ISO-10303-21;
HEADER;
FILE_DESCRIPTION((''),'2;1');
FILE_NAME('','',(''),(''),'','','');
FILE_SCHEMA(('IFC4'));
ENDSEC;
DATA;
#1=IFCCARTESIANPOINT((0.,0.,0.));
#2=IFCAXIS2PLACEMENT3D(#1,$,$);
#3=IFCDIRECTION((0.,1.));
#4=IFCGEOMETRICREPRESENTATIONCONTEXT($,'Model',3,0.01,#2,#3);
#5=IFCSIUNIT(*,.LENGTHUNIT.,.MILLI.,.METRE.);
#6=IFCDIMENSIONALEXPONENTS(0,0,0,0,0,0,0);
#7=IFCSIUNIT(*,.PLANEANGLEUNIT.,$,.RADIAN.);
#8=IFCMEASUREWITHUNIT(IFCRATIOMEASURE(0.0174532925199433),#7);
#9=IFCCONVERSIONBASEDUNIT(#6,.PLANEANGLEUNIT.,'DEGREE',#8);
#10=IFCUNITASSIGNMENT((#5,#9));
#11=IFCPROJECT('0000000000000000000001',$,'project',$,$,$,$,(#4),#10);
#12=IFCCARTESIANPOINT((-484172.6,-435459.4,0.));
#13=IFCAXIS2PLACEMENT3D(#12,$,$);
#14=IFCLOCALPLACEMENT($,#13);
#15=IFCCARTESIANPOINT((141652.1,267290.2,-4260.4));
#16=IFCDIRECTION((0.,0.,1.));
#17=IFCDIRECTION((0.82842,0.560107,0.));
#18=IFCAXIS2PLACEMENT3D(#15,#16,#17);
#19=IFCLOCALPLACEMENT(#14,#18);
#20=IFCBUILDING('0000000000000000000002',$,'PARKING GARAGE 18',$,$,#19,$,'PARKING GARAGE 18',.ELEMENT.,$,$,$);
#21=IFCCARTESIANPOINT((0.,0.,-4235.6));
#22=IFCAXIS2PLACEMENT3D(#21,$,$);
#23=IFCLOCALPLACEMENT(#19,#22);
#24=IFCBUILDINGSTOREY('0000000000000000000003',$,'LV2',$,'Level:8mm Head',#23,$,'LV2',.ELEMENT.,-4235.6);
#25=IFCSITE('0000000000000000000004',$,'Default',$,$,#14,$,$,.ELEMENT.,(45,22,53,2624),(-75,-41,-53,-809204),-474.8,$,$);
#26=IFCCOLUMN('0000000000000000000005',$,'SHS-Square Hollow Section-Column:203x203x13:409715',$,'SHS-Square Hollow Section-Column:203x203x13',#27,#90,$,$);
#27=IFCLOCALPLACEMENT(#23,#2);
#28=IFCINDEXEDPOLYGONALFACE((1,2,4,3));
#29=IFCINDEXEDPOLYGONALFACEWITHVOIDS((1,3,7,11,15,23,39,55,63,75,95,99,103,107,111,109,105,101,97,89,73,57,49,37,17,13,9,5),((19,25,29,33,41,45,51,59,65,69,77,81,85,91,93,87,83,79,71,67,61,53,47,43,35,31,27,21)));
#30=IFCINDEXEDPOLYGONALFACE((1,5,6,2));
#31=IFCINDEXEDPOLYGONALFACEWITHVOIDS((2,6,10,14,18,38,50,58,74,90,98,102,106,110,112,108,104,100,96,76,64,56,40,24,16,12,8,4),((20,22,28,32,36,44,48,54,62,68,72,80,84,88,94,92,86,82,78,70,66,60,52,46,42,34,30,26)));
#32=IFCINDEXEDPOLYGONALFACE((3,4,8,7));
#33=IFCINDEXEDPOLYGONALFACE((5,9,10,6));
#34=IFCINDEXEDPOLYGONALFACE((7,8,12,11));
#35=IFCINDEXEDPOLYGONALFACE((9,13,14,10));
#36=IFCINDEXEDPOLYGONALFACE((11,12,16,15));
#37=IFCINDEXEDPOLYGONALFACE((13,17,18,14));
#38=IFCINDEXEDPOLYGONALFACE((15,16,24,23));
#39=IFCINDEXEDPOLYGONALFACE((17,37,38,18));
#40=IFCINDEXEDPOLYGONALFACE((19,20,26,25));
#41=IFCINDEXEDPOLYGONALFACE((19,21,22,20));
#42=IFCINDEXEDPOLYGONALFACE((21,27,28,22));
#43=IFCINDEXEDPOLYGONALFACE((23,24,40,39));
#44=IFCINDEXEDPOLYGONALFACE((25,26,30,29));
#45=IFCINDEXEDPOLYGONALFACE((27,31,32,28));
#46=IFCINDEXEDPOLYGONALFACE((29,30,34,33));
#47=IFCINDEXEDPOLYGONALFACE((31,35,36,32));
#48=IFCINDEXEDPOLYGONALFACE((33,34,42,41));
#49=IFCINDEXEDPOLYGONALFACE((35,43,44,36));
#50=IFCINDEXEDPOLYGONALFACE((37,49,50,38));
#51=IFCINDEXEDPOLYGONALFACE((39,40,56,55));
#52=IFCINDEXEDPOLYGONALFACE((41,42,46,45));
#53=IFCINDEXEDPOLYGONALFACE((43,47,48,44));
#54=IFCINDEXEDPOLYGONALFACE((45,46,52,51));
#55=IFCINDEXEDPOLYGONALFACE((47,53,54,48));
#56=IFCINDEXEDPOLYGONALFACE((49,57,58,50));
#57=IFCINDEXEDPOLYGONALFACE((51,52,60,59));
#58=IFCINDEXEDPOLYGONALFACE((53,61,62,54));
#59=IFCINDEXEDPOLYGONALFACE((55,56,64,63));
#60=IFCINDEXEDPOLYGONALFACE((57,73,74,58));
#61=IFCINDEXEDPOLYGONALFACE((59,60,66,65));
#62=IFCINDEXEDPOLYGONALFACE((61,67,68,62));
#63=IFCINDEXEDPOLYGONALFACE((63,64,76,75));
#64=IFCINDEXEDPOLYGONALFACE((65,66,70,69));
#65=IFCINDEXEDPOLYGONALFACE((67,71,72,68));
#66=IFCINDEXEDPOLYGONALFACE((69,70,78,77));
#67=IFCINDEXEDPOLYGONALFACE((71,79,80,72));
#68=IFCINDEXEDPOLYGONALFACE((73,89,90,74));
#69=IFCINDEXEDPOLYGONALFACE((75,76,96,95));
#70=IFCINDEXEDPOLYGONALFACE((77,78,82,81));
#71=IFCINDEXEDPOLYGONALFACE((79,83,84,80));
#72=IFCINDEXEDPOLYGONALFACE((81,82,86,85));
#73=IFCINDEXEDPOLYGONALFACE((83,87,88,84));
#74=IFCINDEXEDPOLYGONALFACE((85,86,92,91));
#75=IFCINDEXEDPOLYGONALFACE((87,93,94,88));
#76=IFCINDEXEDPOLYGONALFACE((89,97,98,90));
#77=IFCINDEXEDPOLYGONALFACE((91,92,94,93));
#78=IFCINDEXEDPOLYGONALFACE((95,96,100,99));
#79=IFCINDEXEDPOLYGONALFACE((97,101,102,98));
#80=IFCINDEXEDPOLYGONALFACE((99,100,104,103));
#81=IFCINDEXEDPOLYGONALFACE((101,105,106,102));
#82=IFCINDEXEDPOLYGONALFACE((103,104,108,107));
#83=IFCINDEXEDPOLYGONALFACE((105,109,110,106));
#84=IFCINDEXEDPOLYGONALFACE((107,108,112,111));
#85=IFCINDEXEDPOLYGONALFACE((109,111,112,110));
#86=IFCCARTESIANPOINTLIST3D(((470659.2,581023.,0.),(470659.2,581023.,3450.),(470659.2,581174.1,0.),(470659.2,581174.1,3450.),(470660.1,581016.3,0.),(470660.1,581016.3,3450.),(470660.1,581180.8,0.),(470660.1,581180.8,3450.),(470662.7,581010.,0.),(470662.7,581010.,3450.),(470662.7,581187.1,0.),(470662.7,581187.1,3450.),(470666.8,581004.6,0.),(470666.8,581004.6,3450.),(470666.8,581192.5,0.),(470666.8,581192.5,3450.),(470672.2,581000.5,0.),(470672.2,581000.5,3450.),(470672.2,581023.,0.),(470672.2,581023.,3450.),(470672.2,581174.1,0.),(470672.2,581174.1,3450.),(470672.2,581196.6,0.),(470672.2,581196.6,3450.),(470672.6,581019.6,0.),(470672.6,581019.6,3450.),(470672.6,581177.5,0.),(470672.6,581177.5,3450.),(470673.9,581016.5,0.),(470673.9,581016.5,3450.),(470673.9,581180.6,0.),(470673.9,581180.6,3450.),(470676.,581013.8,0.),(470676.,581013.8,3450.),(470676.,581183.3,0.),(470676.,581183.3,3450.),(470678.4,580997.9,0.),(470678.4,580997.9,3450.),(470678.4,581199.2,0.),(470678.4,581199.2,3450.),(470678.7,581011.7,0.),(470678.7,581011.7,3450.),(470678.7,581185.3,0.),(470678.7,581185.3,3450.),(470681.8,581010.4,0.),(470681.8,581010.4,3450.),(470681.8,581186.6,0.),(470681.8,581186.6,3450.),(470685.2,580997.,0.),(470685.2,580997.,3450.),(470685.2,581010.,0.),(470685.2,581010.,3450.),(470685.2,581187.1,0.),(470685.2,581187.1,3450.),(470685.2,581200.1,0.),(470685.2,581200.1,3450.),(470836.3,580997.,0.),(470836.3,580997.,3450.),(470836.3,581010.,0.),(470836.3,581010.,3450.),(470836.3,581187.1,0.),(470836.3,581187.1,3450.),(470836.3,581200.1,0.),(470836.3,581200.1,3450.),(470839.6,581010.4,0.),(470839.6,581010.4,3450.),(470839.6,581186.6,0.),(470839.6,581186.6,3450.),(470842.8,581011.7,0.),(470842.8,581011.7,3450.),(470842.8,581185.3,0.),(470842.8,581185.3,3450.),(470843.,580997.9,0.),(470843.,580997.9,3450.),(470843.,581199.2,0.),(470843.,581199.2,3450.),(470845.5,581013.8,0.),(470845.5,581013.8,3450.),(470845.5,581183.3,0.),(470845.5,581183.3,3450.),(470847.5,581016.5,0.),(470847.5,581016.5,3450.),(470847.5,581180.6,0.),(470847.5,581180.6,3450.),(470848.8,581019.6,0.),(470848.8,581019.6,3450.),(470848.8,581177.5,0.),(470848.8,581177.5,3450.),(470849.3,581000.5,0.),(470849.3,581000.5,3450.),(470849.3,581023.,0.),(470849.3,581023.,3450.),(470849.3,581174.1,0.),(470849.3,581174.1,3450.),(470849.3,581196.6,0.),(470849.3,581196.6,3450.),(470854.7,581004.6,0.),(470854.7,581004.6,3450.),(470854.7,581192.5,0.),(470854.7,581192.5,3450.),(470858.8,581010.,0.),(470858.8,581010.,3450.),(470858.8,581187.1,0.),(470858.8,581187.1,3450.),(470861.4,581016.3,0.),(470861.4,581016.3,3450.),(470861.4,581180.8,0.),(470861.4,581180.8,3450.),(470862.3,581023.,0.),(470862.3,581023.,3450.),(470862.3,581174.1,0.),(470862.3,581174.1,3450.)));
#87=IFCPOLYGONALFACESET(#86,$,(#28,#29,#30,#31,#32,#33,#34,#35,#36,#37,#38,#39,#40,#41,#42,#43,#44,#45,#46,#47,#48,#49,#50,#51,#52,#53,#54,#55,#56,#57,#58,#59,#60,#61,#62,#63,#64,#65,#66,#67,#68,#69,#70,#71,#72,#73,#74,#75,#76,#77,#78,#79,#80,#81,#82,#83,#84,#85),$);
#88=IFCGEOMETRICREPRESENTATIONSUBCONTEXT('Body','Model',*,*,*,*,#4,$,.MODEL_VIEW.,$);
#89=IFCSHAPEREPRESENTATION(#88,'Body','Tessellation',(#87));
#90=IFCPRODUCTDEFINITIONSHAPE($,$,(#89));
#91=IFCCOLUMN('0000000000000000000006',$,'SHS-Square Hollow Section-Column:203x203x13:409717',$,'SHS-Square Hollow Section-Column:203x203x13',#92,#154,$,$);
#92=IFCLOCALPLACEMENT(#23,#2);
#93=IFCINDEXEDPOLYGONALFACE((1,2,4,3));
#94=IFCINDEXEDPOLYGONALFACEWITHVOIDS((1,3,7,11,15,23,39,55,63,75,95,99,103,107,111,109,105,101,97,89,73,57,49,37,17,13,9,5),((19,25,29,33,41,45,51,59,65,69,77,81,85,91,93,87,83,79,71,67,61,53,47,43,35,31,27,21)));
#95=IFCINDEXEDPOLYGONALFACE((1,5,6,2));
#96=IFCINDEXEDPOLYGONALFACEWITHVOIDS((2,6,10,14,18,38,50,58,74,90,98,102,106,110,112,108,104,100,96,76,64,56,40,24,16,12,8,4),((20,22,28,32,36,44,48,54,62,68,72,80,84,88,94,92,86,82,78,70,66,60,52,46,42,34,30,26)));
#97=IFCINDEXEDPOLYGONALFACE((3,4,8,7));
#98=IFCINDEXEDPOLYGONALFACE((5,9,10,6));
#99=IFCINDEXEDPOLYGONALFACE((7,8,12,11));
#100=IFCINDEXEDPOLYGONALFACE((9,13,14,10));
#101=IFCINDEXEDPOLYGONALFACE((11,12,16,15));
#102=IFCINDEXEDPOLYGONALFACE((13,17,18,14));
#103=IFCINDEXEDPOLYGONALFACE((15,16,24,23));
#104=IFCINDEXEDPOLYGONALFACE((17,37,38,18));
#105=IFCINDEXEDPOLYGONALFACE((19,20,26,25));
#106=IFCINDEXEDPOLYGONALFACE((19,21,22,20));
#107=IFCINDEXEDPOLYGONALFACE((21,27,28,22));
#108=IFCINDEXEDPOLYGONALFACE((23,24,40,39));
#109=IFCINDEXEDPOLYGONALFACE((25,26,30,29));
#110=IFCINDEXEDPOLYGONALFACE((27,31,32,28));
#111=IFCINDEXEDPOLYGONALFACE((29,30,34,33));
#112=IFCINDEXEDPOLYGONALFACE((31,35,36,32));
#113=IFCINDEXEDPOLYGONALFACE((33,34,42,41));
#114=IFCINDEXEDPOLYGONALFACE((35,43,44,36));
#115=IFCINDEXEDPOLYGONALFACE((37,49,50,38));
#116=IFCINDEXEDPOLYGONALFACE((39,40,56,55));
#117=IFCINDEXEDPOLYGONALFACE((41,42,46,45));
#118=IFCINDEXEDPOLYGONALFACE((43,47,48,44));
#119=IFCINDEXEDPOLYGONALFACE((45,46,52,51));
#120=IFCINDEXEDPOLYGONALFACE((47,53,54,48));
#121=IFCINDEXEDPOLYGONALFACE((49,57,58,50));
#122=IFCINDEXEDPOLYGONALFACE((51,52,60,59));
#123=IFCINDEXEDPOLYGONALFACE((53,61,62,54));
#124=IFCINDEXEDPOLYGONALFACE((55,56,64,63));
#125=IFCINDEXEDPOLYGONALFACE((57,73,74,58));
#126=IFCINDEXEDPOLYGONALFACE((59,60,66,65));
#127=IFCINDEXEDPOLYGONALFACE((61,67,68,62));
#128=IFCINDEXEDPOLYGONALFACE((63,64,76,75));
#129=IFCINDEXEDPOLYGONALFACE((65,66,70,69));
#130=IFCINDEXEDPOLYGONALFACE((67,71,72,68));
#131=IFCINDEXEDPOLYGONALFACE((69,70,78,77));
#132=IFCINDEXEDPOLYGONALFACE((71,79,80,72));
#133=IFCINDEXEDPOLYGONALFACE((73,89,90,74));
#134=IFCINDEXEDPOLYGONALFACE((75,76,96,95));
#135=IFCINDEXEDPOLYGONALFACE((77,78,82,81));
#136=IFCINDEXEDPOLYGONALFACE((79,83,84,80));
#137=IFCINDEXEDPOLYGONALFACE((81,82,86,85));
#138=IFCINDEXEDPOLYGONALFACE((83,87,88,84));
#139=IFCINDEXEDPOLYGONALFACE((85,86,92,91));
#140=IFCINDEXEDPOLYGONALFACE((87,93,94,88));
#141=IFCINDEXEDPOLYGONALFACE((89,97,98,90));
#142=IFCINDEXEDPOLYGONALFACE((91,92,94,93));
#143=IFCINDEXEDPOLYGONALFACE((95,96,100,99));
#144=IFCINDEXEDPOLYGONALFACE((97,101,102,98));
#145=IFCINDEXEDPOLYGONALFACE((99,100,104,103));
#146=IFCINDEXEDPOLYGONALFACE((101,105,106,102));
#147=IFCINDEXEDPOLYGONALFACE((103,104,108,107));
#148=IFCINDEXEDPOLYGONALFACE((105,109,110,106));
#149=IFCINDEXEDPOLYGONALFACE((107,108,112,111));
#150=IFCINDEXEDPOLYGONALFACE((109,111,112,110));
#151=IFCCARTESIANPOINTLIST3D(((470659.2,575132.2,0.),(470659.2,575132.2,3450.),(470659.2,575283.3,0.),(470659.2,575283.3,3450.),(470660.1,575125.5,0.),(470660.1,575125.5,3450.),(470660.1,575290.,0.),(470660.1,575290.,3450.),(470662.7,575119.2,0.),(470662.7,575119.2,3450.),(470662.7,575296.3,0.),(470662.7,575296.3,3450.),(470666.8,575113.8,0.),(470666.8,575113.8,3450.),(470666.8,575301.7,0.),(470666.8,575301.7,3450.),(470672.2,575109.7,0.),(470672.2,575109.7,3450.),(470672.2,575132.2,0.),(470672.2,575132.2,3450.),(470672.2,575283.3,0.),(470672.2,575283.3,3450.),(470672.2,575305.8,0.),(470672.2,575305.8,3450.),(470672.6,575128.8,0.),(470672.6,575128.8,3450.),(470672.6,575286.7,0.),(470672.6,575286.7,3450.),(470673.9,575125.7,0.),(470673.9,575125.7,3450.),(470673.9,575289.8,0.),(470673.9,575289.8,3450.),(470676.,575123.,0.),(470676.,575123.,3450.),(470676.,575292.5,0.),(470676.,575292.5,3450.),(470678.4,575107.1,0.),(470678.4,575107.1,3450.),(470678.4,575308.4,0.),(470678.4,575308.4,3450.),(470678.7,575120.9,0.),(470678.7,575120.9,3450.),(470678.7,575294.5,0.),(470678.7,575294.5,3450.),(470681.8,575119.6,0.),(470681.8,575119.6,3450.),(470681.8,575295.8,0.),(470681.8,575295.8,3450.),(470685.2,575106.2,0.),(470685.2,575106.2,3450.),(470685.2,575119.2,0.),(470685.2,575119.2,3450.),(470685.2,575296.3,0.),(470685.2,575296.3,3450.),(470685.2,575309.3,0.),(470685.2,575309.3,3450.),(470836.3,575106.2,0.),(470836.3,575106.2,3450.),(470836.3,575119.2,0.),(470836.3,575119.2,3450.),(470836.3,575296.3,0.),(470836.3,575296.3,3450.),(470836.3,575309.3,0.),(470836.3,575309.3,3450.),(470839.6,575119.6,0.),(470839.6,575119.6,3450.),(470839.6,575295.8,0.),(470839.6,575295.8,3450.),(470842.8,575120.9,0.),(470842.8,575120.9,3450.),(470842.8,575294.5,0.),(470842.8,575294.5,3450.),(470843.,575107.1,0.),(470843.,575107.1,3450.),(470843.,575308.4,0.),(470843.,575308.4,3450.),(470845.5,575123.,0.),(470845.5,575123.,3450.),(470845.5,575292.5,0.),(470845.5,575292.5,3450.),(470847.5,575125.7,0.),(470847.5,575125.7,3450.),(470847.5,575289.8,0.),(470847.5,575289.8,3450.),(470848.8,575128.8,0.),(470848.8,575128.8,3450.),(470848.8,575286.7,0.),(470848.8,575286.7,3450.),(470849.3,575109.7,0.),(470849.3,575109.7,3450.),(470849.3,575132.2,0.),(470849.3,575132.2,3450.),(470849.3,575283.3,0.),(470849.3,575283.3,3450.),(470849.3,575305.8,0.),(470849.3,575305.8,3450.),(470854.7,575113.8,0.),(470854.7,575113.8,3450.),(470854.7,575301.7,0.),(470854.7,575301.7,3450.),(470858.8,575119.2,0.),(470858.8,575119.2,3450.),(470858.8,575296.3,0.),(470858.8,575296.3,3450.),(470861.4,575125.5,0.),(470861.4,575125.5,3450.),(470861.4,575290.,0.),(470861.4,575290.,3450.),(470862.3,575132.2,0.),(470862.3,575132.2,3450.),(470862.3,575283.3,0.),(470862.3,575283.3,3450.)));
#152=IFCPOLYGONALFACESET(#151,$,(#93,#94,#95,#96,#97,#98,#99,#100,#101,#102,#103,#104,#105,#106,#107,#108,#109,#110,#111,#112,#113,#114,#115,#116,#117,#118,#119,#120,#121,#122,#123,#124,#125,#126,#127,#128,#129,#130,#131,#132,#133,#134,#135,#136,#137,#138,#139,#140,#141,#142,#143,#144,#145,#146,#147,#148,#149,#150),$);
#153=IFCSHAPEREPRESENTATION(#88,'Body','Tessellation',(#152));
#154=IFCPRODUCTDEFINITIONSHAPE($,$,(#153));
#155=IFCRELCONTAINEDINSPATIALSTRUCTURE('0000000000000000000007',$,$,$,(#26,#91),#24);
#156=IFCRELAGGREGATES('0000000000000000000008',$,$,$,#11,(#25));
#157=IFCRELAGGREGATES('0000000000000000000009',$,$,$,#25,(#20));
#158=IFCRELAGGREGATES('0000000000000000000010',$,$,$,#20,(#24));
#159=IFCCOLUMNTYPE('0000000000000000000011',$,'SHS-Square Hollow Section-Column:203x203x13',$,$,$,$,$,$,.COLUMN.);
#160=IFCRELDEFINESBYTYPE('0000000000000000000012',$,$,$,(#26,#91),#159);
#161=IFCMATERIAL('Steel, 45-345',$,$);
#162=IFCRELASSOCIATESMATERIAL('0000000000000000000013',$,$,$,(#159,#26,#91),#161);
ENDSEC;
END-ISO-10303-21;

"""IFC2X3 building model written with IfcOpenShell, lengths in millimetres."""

from ifc_helpers import new_model, entity, si_unit, converted_unit, direction, frame, frame_2d, origin, place, context, subcontext, project, spatial, polyline, circle_curve, parameter, trimmed, segment, composite_curve, outline, extrude, source, transform, mapped, material, type_object, type_shapes, element, save


model = new_model("IFC2X3")

# Units and contexts
model_context = context("Model", 3, precision=0.01, world=origin(), true_north=direction((0.0, 1.0)))
body_context = subcontext(model_context, "Body", "Model", "MODEL_VIEW")
ifc_project = project(units=[si_unit("LENGTHUNIT", "METRE", prefix="MILLI"), converted_unit("PLANEANGLEUNIT", "DEGREE", entity("IfcRatioMeasure", 0.0174532925199433), si_unit("PLANEANGLEUNIT", "RADIAN"), dimensions=[0, 0, 0, 0, 0, 0, 0])], contexts=[model_context])

# Site, building, storey
site_placement = place(None, frame((-484172.6, -435459.4, 0.0)))
site = spatial("IfcSite", under=ifc_project, at=site_placement, Name="Default", CompositionType="ELEMENT", RefLatitude=(45, 22, 53, 2624), RefLongitude=(-75, -41, -53, -809204), RefElevation=-474.8)
building_placement = place(site_placement, frame((141652.1, 267290.2, -4260.4), z_axis=(0.0, 0.0, 1.0), x_axis=(0.82842, 0.560107, 0.0)))
building = spatial("IfcBuilding", under=site, at=building_placement, Name="PARKING GARAGE 18", LongName="PARKING GARAGE 18", CompositionType="ELEMENT")
storey_placement = place(building_placement, frame((0.0, 0.0, -4235.6)))
storey = spatial("IfcBuildingStorey", under=building, at=storey_placement, Name="LV2", ObjectType="Level:8mm Head", LongName="LV2", CompositionType="ELEMENT", Elevation=-4235.6)

# Columns
ifc_material_1 = material(Name="Steel, 45-345")
column_type = type_object("IfcColumnType", Name="SHS-Square Hollow Section-Column:203x203x13", PredefinedType="COLUMN", material=ifc_material_1)
shared_shape_1 = source(origin(), body_context, "Body", "SweptSolid", [
    extrude(outline(composite_curve([segment(polyline([(-75.6, -101.5), (75.6, -101.5)]), True, "CONTINUOUS"), segment(trimmed(circle_curve(frame_2d((75.6, -75.6), x_axis=(-1.0, 0.0)), 26.0), [parameter(90.0)], [parameter(180.0)], True, "PARAMETER"), True, "CONTINUOUS"), segment(polyline([(101.5, -75.6), (101.5, 75.6)]), True, "CONTINUOUS"), segment(trimmed(circle_curve(frame_2d((75.5, 75.6), x_axis=(-1.0, 0.0)), 26.0), [parameter(180.0)], [parameter(270.0)], True, "PARAMETER"), True, "CONTINUOUS"), segment(polyline([(75.5, 101.6), (-75.5, 101.6)]), True, "CONTINUOUS"), segment(trimmed(circle_curve(frame_2d((-75.5, 75.5), x_axis=(-1.0, 0.0)), 26.0), [parameter(270.0)], [parameter(360.0)], True, "PARAMETER"), True, "CONTINUOUS"), segment(polyline([(-101.5, 75.5), (-101.5, -75.6)]), True, "CONTINUOUS"), segment(trimmed(circle_curve(frame_2d((-75.6, -75.6), x_axis=(-1.0, 0.0)), 26.0), [parameter(360.0)], [parameter(90.0)], True, "PARAMETER"), True, "CONTINUOUS")], self_intersect=False), holes=[composite_curve([segment(trimmed(circle_curve(frame_2d((-75.6, -75.6), x_axis=(-1.0, 0.0)), 13.0), [parameter(0.0)], [parameter(90.0)], True, "PARAMETER"), False, "CONTINUOUS"), segment(polyline([(-88.5, -75.6), (-88.5, 75.6)]), True, "CONTINUOUS"), segment(trimmed(circle_curve(frame_2d((-75.6, 75.6), x_axis=(-1.0, 0.0)), 13.0), [parameter(270.0)], [parameter(0.0)], True, "PARAMETER"), False, "CONTINUOUS"), segment(polyline([(-75.6, 88.6), (75.5, 88.6)]), True, "CONTINUOUS"), segment(trimmed(circle_curve(frame_2d((75.5, 75.5), x_axis=(-1.0, 0.0)), 13.0), [parameter(180.0)], [parameter(270.0)], True, "PARAMETER"), False, "CONTINUOUS"), segment(polyline([(88.6, 75.5), (88.6, -75.5)]), True, "CONTINUOUS"), segment(trimmed(circle_curve(frame_2d((75.6, -75.5), x_axis=(-1.0, 0.0)), 13.0), [parameter(90.0)], [parameter(180.0)], True, "PARAMETER"), False, "CONTINUOUS"), segment(polyline([(75.6, -88.5), (-75.6, -88.5)]), True, "CONTINUOUS")], self_intersect=False)]), frame((0.0, 0.0, -4235.6), z_axis=(0.0, 0.0, 1.0), x_axis=(-1.0, 0.0, 0.0)), (0.0, 0.0, 1.0), 3450.0),
])
type_shapes(column_type, [shared_shape_1])
for number, where, name in (
    (1, (470760.7, 581098.5, 4235.6), "SHS-Square Hollow Section-Column:203x203x13:409715"),
    (2, (470760.7, 575207.7, 4235.6), "SHS-Square Hollow Section-Column:203x203x13:409717"),
):
    element("IfcColumn", number, at=place(storey_placement, frame(where)), inside=storey, type_object=column_type, material=ifc_material_1, Name=name, ObjectType="SHS-Square Hollow Section-Column:203x203x13", context=body_context, shape_type="MappedRepresentation", body=[
        mapped(shared_shape_1, transform((0.0, 0.0, 0.0), scale=1.0)),
    ])

save(model, "model.ifc")
